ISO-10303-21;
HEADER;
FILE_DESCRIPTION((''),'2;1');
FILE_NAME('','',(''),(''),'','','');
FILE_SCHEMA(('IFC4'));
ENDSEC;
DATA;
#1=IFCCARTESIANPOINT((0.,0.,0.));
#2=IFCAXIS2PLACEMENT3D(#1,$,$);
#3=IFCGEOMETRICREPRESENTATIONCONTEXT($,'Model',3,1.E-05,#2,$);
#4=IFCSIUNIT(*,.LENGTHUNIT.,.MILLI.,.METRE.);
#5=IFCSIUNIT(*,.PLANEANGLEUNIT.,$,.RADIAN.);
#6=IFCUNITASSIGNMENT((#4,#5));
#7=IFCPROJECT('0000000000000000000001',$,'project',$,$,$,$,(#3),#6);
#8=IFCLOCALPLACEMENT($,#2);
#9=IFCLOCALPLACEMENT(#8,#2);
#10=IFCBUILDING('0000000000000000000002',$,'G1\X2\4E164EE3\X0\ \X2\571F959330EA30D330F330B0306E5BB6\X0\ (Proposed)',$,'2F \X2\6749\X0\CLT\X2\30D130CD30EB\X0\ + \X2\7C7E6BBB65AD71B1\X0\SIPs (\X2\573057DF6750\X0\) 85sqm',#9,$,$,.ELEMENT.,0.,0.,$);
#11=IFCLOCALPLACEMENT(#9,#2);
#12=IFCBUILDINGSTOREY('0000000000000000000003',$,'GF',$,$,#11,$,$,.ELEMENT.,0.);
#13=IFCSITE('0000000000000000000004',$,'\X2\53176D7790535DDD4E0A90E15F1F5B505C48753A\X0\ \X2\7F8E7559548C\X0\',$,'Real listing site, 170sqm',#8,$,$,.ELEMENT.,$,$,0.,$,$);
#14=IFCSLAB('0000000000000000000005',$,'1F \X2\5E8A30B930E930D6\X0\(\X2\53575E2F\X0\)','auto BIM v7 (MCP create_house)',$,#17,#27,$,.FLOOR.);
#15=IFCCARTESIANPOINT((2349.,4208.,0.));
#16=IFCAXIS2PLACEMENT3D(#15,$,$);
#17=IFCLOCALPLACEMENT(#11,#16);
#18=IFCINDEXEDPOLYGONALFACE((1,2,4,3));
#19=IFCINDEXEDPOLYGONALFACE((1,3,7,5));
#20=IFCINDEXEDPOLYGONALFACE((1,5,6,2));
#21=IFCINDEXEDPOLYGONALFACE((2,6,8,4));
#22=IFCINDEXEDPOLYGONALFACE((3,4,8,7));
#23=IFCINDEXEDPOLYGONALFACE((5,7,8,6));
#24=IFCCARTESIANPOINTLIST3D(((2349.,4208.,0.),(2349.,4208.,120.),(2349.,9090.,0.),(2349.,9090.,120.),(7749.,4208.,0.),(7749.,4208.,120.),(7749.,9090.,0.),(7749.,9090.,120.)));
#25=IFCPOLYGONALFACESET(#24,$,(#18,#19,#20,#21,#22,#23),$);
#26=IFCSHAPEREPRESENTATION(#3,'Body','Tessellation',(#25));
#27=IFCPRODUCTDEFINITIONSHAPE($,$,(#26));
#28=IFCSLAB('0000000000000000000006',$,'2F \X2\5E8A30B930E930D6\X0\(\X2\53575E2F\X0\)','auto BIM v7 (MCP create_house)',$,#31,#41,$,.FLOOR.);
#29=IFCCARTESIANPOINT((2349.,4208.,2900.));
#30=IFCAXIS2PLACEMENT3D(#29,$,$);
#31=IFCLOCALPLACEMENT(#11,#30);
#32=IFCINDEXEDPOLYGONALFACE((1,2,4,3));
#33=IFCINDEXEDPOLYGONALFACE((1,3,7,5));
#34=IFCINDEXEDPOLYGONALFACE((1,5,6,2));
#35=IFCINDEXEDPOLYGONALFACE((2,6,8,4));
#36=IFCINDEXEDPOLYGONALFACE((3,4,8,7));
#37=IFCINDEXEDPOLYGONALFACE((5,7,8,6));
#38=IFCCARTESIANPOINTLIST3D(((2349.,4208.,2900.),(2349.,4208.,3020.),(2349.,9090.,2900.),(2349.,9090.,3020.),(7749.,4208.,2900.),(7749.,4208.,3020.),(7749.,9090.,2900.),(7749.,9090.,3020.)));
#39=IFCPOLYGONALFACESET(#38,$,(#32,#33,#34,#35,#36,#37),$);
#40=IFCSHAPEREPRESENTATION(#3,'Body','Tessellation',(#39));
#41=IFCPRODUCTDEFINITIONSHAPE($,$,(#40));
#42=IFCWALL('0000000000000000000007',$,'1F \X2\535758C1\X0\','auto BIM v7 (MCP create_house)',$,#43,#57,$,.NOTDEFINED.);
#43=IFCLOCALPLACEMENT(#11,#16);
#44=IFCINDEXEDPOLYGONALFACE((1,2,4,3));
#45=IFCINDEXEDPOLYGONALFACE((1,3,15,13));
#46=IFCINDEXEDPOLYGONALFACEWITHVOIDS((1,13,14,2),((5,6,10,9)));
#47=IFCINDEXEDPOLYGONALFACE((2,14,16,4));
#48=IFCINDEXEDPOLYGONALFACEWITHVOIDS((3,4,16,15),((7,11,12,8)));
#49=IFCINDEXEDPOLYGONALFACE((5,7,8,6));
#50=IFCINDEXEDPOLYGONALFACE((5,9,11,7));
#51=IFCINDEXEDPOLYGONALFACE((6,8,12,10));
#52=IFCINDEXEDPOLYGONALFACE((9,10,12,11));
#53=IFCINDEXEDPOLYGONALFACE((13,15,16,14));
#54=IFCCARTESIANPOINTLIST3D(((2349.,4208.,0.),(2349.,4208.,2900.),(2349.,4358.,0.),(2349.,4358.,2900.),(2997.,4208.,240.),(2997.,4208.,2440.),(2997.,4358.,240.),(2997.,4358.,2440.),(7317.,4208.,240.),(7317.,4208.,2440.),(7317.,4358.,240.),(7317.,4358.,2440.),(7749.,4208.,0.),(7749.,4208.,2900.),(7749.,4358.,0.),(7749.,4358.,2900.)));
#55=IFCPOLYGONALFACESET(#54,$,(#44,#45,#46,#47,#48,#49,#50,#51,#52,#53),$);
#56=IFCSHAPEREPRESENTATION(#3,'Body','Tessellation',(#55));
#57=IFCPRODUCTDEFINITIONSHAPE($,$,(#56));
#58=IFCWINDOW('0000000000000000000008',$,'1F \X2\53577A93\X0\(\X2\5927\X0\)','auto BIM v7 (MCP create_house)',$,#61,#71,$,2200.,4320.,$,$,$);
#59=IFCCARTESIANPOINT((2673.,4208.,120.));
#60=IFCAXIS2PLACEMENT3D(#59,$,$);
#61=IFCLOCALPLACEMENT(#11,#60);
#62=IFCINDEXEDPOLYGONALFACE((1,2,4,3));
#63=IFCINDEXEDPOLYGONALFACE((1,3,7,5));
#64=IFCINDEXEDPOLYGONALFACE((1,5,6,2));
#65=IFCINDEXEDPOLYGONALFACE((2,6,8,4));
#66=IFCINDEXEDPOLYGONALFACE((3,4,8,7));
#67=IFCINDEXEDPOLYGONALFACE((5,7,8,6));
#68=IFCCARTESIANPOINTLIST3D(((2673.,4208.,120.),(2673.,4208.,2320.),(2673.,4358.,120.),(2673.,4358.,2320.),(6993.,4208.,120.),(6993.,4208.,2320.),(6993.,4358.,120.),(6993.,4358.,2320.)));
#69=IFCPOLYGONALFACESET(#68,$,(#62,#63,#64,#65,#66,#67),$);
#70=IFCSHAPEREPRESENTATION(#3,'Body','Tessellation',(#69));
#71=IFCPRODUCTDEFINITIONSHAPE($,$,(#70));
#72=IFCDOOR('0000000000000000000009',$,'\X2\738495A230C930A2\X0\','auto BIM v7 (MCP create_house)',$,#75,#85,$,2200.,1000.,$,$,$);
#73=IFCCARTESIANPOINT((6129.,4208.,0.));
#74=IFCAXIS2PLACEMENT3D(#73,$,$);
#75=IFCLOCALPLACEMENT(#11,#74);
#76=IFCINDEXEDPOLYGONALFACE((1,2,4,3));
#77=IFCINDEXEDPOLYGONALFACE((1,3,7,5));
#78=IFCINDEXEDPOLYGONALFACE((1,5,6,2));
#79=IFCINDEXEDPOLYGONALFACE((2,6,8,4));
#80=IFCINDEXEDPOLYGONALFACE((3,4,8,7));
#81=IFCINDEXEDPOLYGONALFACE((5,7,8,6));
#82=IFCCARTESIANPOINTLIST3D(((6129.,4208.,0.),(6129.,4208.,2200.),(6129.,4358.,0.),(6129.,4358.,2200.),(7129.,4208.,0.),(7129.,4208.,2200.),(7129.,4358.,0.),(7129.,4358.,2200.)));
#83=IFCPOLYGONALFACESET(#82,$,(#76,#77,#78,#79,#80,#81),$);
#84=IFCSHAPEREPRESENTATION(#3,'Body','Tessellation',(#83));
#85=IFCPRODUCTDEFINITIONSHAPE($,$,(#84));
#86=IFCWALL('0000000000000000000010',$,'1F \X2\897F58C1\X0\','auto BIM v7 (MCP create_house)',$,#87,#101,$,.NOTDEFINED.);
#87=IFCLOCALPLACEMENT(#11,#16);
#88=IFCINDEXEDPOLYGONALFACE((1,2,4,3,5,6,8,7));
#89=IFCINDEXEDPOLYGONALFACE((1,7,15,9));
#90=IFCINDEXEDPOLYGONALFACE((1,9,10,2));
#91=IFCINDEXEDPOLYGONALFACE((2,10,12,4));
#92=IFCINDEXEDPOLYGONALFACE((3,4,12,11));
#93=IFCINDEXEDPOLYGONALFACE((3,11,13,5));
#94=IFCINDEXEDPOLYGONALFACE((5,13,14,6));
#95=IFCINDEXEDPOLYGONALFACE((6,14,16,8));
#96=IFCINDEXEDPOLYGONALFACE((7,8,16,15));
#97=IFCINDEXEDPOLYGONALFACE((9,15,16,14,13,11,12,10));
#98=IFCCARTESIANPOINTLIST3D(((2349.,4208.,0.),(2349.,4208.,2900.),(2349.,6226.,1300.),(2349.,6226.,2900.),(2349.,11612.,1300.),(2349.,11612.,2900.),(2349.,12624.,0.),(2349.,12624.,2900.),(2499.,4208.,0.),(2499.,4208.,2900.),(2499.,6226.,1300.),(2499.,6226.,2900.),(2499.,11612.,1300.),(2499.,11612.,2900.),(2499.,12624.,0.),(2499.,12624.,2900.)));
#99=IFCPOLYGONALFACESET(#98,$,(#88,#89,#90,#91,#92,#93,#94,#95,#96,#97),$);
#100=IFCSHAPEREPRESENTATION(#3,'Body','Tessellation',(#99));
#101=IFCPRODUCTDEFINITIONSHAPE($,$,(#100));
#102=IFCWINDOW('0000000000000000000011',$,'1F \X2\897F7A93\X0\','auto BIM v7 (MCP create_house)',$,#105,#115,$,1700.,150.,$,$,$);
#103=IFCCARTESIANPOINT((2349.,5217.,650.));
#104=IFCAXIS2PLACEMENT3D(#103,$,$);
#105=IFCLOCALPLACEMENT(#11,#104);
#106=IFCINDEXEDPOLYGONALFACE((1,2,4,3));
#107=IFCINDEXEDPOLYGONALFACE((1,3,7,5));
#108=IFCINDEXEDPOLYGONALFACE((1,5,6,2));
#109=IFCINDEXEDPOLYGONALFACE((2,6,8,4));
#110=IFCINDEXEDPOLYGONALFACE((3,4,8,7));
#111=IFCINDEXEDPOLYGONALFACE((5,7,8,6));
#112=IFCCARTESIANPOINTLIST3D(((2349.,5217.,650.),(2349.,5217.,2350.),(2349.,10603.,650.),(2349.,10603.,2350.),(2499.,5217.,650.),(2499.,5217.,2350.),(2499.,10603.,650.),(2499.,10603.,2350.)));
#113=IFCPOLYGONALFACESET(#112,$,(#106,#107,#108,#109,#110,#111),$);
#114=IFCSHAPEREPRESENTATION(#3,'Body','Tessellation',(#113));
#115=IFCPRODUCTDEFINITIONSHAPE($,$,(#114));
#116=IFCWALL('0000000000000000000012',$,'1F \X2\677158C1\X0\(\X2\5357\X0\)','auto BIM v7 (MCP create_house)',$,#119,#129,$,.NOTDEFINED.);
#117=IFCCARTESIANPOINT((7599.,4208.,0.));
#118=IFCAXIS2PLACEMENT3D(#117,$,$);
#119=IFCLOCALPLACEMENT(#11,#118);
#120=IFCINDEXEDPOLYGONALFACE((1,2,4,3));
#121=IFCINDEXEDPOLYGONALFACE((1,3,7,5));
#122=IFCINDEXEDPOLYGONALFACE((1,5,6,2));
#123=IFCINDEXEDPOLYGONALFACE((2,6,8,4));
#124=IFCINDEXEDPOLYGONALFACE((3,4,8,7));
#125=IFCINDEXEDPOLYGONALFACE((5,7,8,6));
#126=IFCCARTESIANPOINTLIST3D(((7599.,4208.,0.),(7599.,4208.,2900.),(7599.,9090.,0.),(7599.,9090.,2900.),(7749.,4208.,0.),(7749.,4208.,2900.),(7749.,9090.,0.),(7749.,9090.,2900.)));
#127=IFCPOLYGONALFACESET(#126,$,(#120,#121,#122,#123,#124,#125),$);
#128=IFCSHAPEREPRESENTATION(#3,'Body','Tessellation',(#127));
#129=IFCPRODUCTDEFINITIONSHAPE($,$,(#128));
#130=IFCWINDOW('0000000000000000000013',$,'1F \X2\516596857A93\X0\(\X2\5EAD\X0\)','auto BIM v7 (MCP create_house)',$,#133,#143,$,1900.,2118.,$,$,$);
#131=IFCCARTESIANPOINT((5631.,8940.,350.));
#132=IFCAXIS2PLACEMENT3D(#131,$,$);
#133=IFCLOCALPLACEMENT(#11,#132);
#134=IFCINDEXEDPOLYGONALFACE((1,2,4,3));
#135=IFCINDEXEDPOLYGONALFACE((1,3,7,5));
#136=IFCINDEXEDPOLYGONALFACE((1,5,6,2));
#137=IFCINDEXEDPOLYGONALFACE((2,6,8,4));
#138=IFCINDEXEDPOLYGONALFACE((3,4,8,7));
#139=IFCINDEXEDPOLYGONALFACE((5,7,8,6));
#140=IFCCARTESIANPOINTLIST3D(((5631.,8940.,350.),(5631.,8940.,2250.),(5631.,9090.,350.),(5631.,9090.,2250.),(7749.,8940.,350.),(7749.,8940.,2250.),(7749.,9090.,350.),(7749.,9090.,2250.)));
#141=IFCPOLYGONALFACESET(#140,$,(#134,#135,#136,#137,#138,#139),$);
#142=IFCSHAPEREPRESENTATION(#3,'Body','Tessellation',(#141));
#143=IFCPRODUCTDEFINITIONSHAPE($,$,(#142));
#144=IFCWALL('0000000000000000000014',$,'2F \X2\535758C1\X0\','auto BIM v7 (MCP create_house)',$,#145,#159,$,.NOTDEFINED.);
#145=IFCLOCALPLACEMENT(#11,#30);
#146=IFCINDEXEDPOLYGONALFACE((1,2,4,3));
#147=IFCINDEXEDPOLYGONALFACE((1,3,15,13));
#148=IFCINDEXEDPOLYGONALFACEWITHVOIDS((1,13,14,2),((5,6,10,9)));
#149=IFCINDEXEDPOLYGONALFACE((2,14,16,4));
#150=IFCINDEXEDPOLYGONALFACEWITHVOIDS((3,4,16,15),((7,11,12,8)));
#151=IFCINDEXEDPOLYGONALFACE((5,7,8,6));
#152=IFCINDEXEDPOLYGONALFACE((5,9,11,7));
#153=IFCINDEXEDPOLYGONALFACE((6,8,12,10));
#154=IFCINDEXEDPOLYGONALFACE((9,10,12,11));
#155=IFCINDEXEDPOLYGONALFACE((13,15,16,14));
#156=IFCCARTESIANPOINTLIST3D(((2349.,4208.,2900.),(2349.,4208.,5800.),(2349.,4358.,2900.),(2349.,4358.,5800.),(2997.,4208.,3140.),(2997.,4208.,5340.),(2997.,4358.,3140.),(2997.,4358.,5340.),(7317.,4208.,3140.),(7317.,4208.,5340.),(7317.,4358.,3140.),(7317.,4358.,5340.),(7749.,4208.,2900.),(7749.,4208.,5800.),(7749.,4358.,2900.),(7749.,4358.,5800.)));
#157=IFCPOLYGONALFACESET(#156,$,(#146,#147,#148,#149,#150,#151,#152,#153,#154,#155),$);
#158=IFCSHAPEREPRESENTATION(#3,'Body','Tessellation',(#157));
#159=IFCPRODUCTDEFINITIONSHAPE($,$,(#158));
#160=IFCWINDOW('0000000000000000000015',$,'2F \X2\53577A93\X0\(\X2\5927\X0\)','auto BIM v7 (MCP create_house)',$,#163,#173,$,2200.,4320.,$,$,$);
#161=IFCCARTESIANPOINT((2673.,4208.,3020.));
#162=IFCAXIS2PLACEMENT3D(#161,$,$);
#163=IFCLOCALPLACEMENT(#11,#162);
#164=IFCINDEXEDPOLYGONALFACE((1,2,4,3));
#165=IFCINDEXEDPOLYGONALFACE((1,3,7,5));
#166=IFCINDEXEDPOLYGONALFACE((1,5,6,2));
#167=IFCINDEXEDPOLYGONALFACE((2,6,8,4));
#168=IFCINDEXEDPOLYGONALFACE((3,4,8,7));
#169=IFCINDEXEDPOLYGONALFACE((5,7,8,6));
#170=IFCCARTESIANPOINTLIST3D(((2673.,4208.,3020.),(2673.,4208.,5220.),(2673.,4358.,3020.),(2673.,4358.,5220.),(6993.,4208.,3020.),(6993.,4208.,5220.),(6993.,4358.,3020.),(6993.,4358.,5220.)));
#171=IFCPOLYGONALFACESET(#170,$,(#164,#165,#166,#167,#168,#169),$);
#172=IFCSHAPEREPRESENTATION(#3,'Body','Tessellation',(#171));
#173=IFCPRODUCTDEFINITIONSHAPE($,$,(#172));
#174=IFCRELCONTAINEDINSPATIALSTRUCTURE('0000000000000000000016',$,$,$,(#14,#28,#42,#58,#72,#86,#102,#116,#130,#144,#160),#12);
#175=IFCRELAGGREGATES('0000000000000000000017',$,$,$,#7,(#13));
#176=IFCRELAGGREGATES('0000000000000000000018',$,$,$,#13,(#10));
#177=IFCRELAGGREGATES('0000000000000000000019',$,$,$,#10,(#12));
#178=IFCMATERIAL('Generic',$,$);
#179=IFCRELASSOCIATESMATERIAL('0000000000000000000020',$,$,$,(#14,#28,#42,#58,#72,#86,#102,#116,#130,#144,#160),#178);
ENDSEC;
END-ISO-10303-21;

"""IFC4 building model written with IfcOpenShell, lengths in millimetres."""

from ifc_helpers import new_model, si_unit, frame, frame_2d, origin, place, context, project, spatial, rectangle, extrude, material, element, fill, save


model = new_model("IFC4")

# Units and contexts
model_context = context("Model", 3, precision=1e-05, world=origin())
ifc_project = project(units=[si_unit("LENGTHUNIT", "METRE", prefix="MILLI"), si_unit("PLANEANGLEUNIT", "RADIAN")], contexts=[model_context])

# Site, building, storey
site_placement = place(None, origin())
site = spatial("IfcSite", under=ifc_project, at=site_placement, Name="北海道川上郡弟子屈町 美留和", ObjectType="Real listing site, 170sqm", CompositionType="ELEMENT", RefElevation=0.0)
building_placement = place(site_placement, origin())
building = spatial("IfcBuilding", under=site, at=building_placement, Name="G1世代 土間リビングの家 (Proposed)", ObjectType="2F 杉CLTパネル + 籾殻断熱SIPs (地域材) 85sqm", CompositionType="ELEMENT", ElevationOfRefHeight=0.0, ElevationOfTerrain=0.0)
storey_placement = place(building_placement, origin())
storey = spatial("IfcBuildingStorey", under=building, at=storey_placement, Name="GF", CompositionType="ELEMENT", Elevation=0.0)

# Slabs
ifc_material = material(Name="Generic")
slab_1_placement = place(storey_placement, frame((2349.0, 4208.0, 0.0)))
element("IfcSlab", 1, at=slab_1_placement, inside=storey, material=ifc_material, Name="1F 床スラブ(南帯)", Description="auto BIM v7 (MCP create_house)", PredefinedType="FLOOR", context=model_context, shape_type="SweptSolid", body=[
    extrude(rectangle(XDim=5400.0, YDim=4882.0, at=frame_2d((2700.0, 2441.0))), frame((2349.0, 4208.0, 0.0)), (0.0, 0.0, 1.0), 120.0),
])
slab_2_placement = place(storey_placement, frame((2349.0, 4208.0, 2900.0)))
element("IfcSlab", 2, at=slab_2_placement, inside=storey, material=ifc_material, Name="2F 床スラブ(南帯)", Description="auto BIM v7 (MCP create_house)", PredefinedType="FLOOR", context=model_context, shape_type="SweptSolid", body=[
    extrude(rectangle(XDim=5400.0, YDim=4882.0, at=frame_2d((2700.0, 2441.0))), frame((2349.0, 4208.0, 2900.0)), (0.0, 0.0, 1.0), 120.0),
])

# Wall, openings, window, door
wall_1_placement = place(storey_placement, frame((2349.0, 4208.0, 0.0)))
wall_1 = element("IfcWall", 3, at=wall_1_placement, inside=storey, material=ifc_material, Name="1F 南壁", Description="auto BIM v7 (MCP create_house)", PredefinedType="NOTDEFINED", context=model_context, shape_type="SweptSolid", body=[
    extrude(rectangle(XDim=5400.0, YDim=150.0, at=frame_2d((2700.0, 75.0))), frame((2349.0, 4208.0, 0.0)), (0.0, 0.0, 1.0), 2900.0),
])
opening_1_placement = place(storey_placement, frame((2673.0, 4208.0, 120.0)))
opening_1 = element("IfcOpeningElement", 4, at=opening_1_placement, cuts=wall_1, PredefinedType="NOTDEFINED", context=model_context, shape_type="SweptSolid", body=[
    extrude(rectangle(XDim=4320.0, YDim=150.0, at=frame_2d((2160.0, 75.0))), frame((2673.0, 4208.0, 120.0)), (0.0, 0.0, 1.0), 2200.0),
])
opening_2_placement = place(storey_placement, frame((6129.0, 4208.0, 0.0)))
opening_2 = element("IfcOpeningElement", 5, at=opening_2_placement, cuts=wall_1, PredefinedType="NOTDEFINED", context=model_context, shape_type="SweptSolid", body=[
    extrude(rectangle(XDim=1000.0, YDim=150.0, at=frame_2d((500.0, 75.0))), frame((6129.0, 4208.0, 0.0)), (0.0, 0.0, 1.0), 2200.0),
])
window_1_placement = place(storey_placement, frame((2673.0, 4208.0, 120.0)))
window_1 = element("IfcWindow", 6, at=window_1_placement, inside=storey, material=ifc_material, Name="1F 南窓(大)", Description="auto BIM v7 (MCP create_house)", OverallHeight=2200.0, OverallWidth=4320.0, context=model_context, shape_type="SweptSolid", body=[
    extrude(rectangle(XDim=4320.0, YDim=150.0, at=frame_2d((2160.0, 75.0))), frame((2673.0, 4208.0, 120.0)), (0.0, 0.0, 1.0), 2200.0),
])
fill(opening_1, window_1)
door_placement = place(storey_placement, frame((6129.0, 4208.0, 0.0)))
door = element("IfcDoor", 7, at=door_placement, inside=storey, material=ifc_material, Name="玄関ドア", Description="auto BIM v7 (MCP create_house)", OverallHeight=2200.0, OverallWidth=1000.0, context=model_context, shape_type="SweptSolid", body=[
    extrude(rectangle(XDim=1000.0, YDim=150.0, at=frame_2d((500.0, 75.0))), frame((6129.0, 4208.0, 0.0)), (0.0, 0.0, 1.0), 2200.0),
])
fill(opening_2, door)

# Walls, openings, windows
wall_2_placement = place(storey_placement, frame((2349.0, 4208.0, 0.0)))
wall_2 = element("IfcWall", 8, at=wall_2_placement, inside=storey, material=ifc_material, Name="1F 西壁", Description="auto BIM v7 (MCP create_house)", PredefinedType="NOTDEFINED", context=model_context, shape_type="SweptSolid", body=[
    extrude(rectangle(XDim=150.0, YDim=8416.0, at=frame_2d((75.0, 4208.0))), frame((2349.0, 4208.0, 0.0)), (0.0, 0.0, 1.0), 2900.0),
])
opening_3_placement = place(storey_placement, frame((2349.0, 5217.0, 650.0)))
opening_3 = element("IfcOpeningElement", 9, at=opening_3_placement, cuts=wall_2, PredefinedType="NOTDEFINED", context=model_context, shape_type="SweptSolid", body=[
    extrude(rectangle(XDim=150.0, YDim=5386.0, at=frame_2d((75.0, 2693.0))), frame((2349.0, 5217.0, 650.0)), (0.0, 0.0, 1.0), 1700.0),
])
window_2_placement = place(storey_placement, frame((2349.0, 5217.0, 650.0)))
window_2 = element("IfcWindow", 10, at=window_2_placement, inside=storey, material=ifc_material, Name="1F 西窓", Description="auto BIM v7 (MCP create_house)", OverallHeight=1700.0, OverallWidth=150.0, context=model_context, shape_type="SweptSolid", body=[
    extrude(rectangle(XDim=150.0, YDim=5386.0, at=frame_2d((75.0, 2693.0))), frame((2349.0, 5217.0, 650.0)), (0.0, 0.0, 1.0), 1700.0),
])
fill(opening_3, window_2)
wall_3_placement = place(storey_placement, frame((7599.0, 4208.0, 0.0)))
wall_3 = element("IfcWall", 11, at=wall_3_placement, inside=storey, material=ifc_material, Name="1F 東壁(南)", Description="auto BIM v7 (MCP create_house)", PredefinedType="NOTDEFINED", context=model_context, shape_type="SweptSolid", body=[
    extrude(rectangle(XDim=150.0, YDim=4882.0, at=frame_2d((75.0, 2441.0))), frame((7599.0, 4208.0, 0.0)), (0.0, 0.0, 1.0), 2900.0),
])
opening_4_placement = place(storey_placement, frame((5631.0, 8940.0, 350.0)))
opening_4 = element("IfcOpeningElement", 12, at=opening_4_placement, cuts=wall_3, PredefinedType="NOTDEFINED", context=model_context, shape_type="SweptSolid", body=[
    extrude(rectangle(XDim=2118.0, YDim=150.0, at=frame_2d((1059.0, 75.0))), frame((5631.0, 8940.0, 350.0)), (0.0, 0.0, 1.0), 1900.0),
])
window_3_placement = place(storey_placement, frame((5631.0, 8940.0, 350.0)))
window_3 = element("IfcWindow", 13, at=window_3_placement, inside=storey, material=ifc_material, Name="1F 入隅窓(庭)", Description="auto BIM v7 (MCP create_house)", OverallHeight=1900.0, OverallWidth=2118.0, context=model_context, shape_type="SweptSolid", body=[
    extrude(rectangle(XDim=2118.0, YDim=150.0, at=frame_2d((1059.0, 75.0))), frame((5631.0, 8940.0, 350.0)), (0.0, 0.0, 1.0), 1900.0),
])
fill(opening_4, window_3)

# Wall, opening, window
wall_4_placement = place(storey_placement, frame((2349.0, 4208.0, 2900.0)))
wall_4 = element("IfcWall", 14, at=wall_4_placement, inside=storey, material=ifc_material, Name="2F 南壁", Description="auto BIM v7 (MCP create_house)", PredefinedType="NOTDEFINED", context=model_context, shape_type="SweptSolid", body=[
    extrude(rectangle(XDim=5400.0, YDim=150.0, at=frame_2d((2700.0, 75.0))), frame((2349.0, 4208.0, 2900.0)), (0.0, 0.0, 1.0), 2900.0),
])
opening_5_placement = place(storey_placement, frame((2673.0, 4208.0, 3020.0)))
opening_5 = element("IfcOpeningElement", 15, at=opening_5_placement, cuts=wall_4, PredefinedType="NOTDEFINED", context=model_context, shape_type="SweptSolid", body=[
    extrude(rectangle(XDim=4320.0, YDim=150.0, at=frame_2d((2160.0, 75.0))), frame((2673.0, 4208.0, 3020.0)), (0.0, 0.0, 1.0), 2200.0),
])
window_4_placement = place(storey_placement, frame((2673.0, 4208.0, 3020.0)))
window_4 = element("IfcWindow", 16, at=window_4_placement, inside=storey, material=ifc_material, Name="2F 南窓(大)", Description="auto BIM v7 (MCP create_house)", OverallHeight=2200.0, OverallWidth=4320.0, context=model_context, shape_type="SweptSolid", body=[
    extrude(rectangle(XDim=4320.0, YDim=150.0, at=frame_2d((2160.0, 75.0))), frame((2673.0, 4208.0, 3020.0)), (0.0, 0.0, 1.0), 2200.0),
])
fill(opening_5, window_4)

save(model, "model.ifc")
